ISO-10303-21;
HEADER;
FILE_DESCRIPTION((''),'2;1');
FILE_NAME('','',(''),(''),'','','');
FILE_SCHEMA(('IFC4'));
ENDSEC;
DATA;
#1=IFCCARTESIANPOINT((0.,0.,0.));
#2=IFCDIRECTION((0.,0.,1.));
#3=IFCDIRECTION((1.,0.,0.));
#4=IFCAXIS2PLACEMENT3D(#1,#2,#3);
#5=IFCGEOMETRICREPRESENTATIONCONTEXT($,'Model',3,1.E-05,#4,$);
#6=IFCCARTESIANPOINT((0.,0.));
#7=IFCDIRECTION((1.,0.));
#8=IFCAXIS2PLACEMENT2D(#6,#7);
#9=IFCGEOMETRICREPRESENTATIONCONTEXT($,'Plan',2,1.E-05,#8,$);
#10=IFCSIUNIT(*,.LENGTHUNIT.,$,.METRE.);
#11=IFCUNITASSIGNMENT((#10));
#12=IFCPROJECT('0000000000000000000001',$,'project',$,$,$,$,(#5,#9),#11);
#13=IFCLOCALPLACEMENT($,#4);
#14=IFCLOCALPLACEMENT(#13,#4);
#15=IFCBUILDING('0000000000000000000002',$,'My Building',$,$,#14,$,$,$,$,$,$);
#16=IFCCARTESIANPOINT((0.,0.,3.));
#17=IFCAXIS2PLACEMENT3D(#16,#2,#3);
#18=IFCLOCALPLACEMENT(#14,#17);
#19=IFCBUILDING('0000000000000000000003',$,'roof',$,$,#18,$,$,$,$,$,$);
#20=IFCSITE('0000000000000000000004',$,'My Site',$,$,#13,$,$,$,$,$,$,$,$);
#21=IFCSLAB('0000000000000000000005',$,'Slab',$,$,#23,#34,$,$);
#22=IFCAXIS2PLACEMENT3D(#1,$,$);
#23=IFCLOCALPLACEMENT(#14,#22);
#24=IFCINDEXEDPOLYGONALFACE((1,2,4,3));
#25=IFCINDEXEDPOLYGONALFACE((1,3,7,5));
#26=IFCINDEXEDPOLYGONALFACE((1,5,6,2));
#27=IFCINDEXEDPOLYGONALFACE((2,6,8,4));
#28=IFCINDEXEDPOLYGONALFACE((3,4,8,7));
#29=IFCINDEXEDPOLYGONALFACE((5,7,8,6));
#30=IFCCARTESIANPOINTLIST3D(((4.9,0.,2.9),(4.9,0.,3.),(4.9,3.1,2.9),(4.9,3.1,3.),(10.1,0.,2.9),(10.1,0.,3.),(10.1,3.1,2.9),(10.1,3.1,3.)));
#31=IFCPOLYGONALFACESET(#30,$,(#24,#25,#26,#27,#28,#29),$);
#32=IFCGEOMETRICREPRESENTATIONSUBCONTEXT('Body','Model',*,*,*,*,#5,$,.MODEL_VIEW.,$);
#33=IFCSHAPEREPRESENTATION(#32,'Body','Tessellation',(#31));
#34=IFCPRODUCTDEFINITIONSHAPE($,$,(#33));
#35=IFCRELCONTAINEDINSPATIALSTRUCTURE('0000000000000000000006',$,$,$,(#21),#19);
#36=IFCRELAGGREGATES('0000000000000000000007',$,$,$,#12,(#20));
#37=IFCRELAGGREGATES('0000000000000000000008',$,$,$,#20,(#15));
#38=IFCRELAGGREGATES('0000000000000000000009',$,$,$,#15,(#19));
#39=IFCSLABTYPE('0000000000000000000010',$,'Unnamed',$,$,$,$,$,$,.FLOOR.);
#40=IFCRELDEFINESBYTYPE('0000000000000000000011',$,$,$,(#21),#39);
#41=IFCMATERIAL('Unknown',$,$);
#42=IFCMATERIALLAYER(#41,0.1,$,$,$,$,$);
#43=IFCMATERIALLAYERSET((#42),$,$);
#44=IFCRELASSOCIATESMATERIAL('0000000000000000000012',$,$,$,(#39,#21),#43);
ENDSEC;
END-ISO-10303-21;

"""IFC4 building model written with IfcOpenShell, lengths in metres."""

from ifc_helpers import new_model, si_unit, frame, origin_with_axes, origin_2d_with_axis, place, context, subcontext, project, spatial, indexed_curve, outline, extrude, material, layer, layer_set, layer_usage, type_object, element, save


model = new_model("IFC4")

# Units and contexts
model_context = context("Model", 3, precision=1e-05, world=origin_with_axes())
plan_context = context("Plan", 2, precision=1e-05, world=origin_2d_with_axis())
body_context = subcontext(model_context, "Body", "Model", "MODEL_VIEW")
ifc_project = project(units=[si_unit("LENGTHUNIT", "METRE")], contexts=[model_context, plan_context])

# Site, buildings
site_placement = place(None, origin_with_axes())
site = spatial("IfcSite", under=ifc_project, at=site_placement, Name="My Site")
building_1_placement = place(site_placement, origin_with_axes())
building_1 = spatial("IfcBuilding", under=site, at=building_1_placement, Name="My Building")
building_2_placement = place(building_1_placement, frame((0.0, 0.0, 3.0), z_axis=(0.0, 0.0, 1.0), x_axis=(1.0, 0.0, 0.0)))
building_2 = spatial("IfcBuilding", under=building_1, at=building_2_placement, Name="roof")

# Slab
ifc_material = material(Name="Unknown")
ifc_layer = layer(ifc_material, 0.1)
ifc_layer_set = layer_set([ifc_layer])
ifc_layer_usage = layer_usage(ifc_layer_set, "AXIS3", "POSITIVE", -0.1)
slab_type = type_object("IfcSlabType", Name="Unnamed", PredefinedType="FLOOR", material=ifc_layer_set)
slab_placement = place(building_2_placement, frame((4.9, 3.1, 0.0), z_axis=(0.0, 0.0, 1.0), x_axis=(1.0, 0.0, 0.0)))
element("IfcSlab", 1, at=slab_placement, inside=building_2, type_object=slab_type, material=ifc_layer_usage, Name="Slab", context=body_context, shape_type="SweptSolid", body=[
    extrude(outline(indexed_curve([(0.0, 0.0), (0.0, -3.1), (5.2, -3.1), (5.2, 0.0), (0.0, 0.0)])), frame((0.0, 0.0, -0.1), z_axis=(0.0, 0.0, 1.0), x_axis=(1.0, 0.0, 0.0)), (0.0, 0.0, 1.0), 0.1),
])

save(model, "model.ifc")
